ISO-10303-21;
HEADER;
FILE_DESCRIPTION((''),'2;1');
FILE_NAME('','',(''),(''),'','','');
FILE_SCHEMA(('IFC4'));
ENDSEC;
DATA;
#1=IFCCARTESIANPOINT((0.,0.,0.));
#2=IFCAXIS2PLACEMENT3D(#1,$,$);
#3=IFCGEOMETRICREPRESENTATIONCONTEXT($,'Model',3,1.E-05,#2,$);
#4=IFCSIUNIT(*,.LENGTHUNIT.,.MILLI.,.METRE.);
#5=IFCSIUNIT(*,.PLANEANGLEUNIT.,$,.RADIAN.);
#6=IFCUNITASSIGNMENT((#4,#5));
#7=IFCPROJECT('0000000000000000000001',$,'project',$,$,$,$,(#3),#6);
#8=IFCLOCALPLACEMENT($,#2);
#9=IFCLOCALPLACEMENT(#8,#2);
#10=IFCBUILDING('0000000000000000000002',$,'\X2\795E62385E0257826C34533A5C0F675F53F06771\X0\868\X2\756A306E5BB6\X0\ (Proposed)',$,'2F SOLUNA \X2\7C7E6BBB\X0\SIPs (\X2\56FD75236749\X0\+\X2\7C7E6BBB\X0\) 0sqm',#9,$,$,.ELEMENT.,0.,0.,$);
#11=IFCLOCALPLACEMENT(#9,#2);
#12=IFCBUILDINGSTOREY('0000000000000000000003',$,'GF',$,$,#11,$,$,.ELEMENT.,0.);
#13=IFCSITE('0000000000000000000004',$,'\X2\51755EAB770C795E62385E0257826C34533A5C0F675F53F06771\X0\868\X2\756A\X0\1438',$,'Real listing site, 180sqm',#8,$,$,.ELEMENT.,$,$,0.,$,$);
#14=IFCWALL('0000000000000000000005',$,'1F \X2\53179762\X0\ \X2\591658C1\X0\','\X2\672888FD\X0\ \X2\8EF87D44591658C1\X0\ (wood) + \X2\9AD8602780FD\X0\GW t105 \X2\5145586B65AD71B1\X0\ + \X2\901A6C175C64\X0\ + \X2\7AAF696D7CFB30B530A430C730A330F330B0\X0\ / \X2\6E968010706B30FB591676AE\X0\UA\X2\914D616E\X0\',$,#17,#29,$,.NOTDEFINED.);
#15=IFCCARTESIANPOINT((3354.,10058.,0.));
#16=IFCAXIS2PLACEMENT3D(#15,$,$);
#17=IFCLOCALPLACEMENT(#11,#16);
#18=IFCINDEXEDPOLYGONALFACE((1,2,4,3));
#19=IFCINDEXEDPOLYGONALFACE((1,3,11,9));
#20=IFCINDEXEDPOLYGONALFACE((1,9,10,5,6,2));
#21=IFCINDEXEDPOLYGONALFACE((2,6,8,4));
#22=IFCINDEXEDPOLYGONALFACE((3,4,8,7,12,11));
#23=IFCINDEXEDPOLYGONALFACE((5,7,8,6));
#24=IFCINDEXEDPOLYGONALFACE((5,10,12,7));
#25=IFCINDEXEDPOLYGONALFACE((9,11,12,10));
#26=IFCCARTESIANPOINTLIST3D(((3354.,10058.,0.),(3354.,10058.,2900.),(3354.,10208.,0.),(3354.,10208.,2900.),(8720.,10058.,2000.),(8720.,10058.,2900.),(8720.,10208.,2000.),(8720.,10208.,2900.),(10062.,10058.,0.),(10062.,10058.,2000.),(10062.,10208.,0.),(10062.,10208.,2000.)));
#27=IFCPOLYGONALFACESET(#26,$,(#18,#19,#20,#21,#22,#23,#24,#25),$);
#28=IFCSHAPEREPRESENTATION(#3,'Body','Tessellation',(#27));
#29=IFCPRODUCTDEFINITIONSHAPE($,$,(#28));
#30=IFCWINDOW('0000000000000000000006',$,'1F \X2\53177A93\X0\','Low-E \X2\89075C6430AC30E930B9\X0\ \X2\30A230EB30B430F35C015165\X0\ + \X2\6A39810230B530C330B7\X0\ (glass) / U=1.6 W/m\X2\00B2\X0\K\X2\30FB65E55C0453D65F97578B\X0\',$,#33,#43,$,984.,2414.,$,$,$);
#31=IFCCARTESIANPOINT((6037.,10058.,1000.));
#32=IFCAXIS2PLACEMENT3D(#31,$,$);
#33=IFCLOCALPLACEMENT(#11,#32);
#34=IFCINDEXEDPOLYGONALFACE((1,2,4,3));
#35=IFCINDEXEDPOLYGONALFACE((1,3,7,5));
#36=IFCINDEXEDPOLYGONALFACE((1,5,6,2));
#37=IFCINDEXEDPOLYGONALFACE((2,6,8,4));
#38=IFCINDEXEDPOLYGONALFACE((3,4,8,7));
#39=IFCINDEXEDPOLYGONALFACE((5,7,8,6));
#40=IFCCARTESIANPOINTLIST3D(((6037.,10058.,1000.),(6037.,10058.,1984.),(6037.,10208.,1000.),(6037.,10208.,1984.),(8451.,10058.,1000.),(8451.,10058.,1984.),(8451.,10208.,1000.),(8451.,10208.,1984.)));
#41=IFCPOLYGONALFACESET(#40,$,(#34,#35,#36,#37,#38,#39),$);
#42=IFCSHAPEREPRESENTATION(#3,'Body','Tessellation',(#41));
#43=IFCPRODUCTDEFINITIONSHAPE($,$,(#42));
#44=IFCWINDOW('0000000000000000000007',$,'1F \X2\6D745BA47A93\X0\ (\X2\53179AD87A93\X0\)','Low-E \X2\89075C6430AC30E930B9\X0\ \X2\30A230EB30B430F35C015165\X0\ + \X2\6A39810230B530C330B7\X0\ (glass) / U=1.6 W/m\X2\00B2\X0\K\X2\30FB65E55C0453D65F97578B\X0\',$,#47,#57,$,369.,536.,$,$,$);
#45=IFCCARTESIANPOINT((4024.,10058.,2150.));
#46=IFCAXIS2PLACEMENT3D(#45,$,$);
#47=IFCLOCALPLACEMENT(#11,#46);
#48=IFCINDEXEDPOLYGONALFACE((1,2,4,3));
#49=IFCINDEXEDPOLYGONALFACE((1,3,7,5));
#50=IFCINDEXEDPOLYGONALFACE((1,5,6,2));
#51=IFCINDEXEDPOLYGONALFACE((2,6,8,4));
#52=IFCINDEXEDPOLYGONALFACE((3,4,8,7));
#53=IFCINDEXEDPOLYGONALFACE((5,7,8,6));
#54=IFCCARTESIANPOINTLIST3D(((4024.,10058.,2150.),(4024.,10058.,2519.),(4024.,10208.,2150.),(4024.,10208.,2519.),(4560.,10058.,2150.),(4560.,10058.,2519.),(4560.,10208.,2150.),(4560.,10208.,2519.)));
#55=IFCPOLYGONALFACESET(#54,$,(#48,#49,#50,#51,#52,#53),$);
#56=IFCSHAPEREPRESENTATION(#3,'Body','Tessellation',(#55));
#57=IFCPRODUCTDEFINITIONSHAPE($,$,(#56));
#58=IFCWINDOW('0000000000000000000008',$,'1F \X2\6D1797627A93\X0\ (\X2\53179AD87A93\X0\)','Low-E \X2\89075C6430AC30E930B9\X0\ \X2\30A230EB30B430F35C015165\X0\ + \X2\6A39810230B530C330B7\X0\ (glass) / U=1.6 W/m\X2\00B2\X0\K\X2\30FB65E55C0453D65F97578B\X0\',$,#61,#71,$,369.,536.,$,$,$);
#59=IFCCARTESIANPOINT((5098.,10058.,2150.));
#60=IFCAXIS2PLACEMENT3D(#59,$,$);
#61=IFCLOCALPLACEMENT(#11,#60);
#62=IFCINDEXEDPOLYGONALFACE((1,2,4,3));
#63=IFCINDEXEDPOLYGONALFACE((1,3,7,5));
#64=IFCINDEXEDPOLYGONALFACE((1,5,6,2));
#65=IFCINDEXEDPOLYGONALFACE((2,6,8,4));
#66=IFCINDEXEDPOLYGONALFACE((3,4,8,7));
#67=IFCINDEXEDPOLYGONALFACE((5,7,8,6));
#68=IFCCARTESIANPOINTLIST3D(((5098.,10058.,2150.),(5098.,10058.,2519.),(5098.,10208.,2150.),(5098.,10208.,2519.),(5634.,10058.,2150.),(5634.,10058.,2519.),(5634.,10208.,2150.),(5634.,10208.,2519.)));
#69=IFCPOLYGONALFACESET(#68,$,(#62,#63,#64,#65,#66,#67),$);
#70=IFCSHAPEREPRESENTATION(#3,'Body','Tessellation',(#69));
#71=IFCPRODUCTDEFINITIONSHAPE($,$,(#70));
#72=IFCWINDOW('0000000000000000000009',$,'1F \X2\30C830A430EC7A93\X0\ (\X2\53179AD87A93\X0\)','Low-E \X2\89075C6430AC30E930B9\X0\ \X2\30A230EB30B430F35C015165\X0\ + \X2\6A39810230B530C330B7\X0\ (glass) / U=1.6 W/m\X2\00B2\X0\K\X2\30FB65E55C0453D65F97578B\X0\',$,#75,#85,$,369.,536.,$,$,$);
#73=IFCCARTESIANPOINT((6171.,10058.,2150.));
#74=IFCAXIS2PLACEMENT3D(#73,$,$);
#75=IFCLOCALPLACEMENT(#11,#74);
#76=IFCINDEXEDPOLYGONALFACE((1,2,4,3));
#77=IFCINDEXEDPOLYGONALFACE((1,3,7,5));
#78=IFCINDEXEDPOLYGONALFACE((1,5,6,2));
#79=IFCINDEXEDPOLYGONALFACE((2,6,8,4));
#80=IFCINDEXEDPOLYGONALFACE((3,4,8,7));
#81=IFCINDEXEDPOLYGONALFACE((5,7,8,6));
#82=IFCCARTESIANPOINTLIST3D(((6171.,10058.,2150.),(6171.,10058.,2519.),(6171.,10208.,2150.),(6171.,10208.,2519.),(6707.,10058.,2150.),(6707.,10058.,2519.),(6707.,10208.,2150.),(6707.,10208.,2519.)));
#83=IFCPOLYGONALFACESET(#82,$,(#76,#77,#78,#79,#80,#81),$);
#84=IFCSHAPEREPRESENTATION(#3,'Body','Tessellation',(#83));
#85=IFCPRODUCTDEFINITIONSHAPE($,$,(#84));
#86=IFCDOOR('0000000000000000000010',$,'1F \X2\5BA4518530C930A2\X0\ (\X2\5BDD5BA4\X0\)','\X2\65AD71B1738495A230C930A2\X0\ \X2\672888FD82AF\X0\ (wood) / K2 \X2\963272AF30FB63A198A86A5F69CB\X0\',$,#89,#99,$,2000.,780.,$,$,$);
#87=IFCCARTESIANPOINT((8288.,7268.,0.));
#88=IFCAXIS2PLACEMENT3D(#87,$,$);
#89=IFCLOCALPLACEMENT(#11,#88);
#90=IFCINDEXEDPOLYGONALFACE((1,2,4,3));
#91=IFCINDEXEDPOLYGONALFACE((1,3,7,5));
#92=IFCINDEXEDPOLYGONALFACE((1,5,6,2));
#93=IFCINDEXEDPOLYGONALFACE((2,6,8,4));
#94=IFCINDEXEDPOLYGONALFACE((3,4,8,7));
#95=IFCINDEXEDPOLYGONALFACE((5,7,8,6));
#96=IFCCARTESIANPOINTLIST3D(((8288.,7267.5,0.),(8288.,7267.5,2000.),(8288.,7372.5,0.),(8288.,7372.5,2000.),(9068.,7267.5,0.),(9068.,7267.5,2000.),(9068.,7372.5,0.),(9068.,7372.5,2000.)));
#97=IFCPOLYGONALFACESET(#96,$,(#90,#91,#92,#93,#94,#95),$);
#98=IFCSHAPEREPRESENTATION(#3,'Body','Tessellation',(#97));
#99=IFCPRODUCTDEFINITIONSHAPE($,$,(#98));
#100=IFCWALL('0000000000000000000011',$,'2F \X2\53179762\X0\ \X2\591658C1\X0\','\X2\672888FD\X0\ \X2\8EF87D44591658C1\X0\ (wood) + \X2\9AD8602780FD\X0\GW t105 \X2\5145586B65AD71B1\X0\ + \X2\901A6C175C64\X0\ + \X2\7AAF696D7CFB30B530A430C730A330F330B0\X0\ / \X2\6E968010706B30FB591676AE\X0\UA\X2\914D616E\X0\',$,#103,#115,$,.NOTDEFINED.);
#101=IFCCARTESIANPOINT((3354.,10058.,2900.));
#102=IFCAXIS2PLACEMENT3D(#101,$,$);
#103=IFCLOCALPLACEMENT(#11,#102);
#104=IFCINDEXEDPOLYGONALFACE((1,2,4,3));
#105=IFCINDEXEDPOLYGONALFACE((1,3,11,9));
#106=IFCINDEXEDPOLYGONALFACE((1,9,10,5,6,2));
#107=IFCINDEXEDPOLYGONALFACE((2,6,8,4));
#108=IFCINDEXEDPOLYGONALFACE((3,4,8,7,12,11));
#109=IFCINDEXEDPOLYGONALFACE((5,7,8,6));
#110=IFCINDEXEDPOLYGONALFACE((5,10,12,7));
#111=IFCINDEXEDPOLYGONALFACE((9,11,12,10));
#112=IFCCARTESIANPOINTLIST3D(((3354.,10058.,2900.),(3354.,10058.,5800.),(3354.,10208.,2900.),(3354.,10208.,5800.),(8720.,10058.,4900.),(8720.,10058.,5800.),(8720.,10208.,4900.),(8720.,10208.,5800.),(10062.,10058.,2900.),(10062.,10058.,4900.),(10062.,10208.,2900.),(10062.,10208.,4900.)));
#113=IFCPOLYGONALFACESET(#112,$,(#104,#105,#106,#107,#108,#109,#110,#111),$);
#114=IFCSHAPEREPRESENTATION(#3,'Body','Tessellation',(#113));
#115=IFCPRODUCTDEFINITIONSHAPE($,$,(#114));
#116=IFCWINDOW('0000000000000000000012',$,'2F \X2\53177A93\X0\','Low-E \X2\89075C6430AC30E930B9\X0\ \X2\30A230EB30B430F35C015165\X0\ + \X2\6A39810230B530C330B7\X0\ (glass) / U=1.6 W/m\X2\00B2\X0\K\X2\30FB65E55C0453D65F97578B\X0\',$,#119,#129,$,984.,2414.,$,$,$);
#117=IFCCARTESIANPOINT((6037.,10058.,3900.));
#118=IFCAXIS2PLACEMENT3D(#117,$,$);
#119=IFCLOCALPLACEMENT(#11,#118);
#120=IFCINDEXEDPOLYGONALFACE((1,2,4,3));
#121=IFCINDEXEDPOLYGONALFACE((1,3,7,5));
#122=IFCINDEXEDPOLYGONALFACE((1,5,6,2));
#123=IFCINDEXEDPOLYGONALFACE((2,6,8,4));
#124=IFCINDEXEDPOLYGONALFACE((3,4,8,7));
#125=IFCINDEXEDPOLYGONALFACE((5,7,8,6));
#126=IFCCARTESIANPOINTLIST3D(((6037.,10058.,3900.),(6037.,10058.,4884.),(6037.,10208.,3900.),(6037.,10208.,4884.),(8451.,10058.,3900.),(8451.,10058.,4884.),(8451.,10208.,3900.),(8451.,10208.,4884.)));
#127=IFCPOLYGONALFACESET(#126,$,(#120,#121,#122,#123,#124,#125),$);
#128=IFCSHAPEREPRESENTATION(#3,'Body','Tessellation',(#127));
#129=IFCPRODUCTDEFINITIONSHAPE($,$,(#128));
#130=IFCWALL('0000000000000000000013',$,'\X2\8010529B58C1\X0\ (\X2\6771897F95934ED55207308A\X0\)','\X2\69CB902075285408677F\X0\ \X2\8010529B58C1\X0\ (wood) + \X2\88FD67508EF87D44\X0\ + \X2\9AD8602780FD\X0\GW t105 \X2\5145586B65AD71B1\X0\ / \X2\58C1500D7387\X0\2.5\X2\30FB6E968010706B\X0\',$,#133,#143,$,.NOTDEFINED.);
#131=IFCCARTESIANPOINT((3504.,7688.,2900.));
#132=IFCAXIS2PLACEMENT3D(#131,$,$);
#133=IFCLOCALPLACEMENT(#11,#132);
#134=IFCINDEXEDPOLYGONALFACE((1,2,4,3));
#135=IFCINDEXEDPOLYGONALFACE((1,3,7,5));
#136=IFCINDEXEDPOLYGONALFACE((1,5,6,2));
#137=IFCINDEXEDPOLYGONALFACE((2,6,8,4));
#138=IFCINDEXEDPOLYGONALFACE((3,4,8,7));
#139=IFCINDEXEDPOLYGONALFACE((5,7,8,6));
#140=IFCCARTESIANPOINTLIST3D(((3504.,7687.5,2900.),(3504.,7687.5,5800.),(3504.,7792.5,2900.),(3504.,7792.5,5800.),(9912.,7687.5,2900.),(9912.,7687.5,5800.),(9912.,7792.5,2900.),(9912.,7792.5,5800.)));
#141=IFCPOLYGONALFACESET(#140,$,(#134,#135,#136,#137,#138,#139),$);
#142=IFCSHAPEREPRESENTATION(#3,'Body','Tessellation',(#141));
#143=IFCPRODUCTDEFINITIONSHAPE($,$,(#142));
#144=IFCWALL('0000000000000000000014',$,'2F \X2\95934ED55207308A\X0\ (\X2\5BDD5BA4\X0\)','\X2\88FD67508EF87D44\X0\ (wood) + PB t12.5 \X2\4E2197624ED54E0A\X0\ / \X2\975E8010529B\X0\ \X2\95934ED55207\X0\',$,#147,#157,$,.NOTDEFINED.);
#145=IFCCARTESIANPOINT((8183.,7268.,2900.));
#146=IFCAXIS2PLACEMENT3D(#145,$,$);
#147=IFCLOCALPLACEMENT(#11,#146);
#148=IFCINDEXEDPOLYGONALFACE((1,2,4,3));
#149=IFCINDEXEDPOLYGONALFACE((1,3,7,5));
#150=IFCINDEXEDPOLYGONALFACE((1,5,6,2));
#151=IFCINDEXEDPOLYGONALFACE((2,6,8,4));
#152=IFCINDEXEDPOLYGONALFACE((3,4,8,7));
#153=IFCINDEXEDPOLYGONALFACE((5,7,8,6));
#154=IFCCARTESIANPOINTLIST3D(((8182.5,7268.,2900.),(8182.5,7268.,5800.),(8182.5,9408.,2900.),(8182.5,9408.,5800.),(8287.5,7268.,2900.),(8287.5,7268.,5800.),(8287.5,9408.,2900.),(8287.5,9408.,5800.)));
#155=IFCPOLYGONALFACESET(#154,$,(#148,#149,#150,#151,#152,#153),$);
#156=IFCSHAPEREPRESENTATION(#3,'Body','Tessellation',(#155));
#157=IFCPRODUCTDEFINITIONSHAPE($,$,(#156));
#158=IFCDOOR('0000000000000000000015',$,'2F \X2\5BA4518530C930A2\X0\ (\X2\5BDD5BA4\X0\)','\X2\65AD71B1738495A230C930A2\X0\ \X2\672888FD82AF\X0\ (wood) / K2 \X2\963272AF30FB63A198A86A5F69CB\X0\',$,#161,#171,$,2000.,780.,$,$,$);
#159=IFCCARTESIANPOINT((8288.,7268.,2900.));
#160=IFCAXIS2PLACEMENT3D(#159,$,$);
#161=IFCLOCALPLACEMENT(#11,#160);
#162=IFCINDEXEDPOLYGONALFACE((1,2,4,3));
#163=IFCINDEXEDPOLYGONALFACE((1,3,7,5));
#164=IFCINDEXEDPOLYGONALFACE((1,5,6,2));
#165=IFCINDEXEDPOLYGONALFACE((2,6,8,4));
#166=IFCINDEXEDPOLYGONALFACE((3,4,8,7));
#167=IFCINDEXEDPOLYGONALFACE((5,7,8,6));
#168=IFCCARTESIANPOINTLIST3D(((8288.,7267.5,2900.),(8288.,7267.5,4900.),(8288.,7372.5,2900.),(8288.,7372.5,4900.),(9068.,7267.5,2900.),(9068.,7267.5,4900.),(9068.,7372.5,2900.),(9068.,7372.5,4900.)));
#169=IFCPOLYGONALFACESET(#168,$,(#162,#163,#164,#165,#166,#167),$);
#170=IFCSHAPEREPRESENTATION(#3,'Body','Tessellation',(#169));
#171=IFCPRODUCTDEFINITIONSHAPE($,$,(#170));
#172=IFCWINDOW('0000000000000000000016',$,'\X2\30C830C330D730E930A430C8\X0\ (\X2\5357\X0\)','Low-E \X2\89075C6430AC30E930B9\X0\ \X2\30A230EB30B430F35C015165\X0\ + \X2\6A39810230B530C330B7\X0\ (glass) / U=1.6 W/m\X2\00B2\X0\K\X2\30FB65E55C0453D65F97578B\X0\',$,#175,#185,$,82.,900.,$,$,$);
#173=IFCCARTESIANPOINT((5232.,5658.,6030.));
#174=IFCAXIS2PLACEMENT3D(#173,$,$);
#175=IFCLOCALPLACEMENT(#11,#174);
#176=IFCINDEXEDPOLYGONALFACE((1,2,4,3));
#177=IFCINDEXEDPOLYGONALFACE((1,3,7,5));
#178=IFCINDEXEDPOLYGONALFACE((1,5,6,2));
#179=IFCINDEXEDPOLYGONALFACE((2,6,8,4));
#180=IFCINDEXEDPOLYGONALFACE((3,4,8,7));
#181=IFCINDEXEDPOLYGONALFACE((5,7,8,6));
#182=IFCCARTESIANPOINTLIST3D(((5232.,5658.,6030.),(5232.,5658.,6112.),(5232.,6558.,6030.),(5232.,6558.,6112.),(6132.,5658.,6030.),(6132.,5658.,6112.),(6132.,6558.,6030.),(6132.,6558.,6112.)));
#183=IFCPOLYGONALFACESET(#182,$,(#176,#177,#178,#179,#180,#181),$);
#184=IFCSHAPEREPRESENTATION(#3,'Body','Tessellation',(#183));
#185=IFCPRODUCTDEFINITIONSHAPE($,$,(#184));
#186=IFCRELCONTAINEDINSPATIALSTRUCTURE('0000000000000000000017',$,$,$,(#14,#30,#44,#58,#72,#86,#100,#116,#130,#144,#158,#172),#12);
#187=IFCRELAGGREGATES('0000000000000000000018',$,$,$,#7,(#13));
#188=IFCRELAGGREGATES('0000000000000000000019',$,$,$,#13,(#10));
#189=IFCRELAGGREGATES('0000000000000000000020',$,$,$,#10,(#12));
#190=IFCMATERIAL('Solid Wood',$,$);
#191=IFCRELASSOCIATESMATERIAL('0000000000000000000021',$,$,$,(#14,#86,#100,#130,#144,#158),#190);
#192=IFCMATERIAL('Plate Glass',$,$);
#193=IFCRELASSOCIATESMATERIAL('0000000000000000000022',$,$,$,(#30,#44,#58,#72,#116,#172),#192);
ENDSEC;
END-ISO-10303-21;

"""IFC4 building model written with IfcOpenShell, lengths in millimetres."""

from ifc_helpers import new_model, si_unit, frame, frame_2d, origin, place, context, project, spatial, rectangle, extrude, material, element, fill, save


model = new_model("IFC4")

# Units and contexts
model_context = context("Model", 3, precision=1e-05, world=origin())
ifc_project = project(units=[si_unit("LENGTHUNIT", "METRE", prefix="MILLI"), si_unit("PLANEANGLEUNIT", "RADIAN")], contexts=[model_context])

# Site, building, storey
site_placement = place(None, origin())
site = spatial("IfcSite", under=ifc_project, at=site_placement, Name="兵庫県神戸市垂水区小束台東868番1438", ObjectType="Real listing site, 180sqm", CompositionType="ELEMENT", RefElevation=0.0)
building_placement = place(site_placement, origin())
building = spatial("IfcBuilding", under=site, at=building_placement, Name="神戸市垂水区小束台東868番の家 (Proposed)", ObjectType="2F SOLUNA 籾殻SIPs (国産杉+籾殻) 0sqm", CompositionType="ELEMENT", ElevationOfRefHeight=0.0, ElevationOfTerrain=0.0)
storey_placement = place(building_placement, origin())
storey = spatial("IfcBuildingStorey", under=building, at=storey_placement, Name="GF", CompositionType="ELEMENT", Elevation=0.0)

# Wall, openings, windows
ifc_material_1 = material(Name="Solid Wood")
wall_1_placement = place(storey_placement, frame((3354.0, 10058.0, 0.0)))
wall_1 = element("IfcWall", 1, at=wall_1_placement, inside=storey, material=ifc_material_1, Name="1F 北面 外壁", Description="木製 軸組外壁 (wood) + 高性能GW t105 充填断熱 + 通気層 + 窯業系サイディング / 準耐火・外皮UA配慮", PredefinedType="NOTDEFINED", context=model_context, shape_type="SweptSolid", body=[
    extrude(rectangle(XDim=6708.0, YDim=150.0, at=frame_2d((3354.0, 75.0))), frame((3354.0, 10058.0, 0.0)), (0.0, 0.0, 1.0), 2900.0),
])
opening_1_placement = place(storey_placement, frame((6037.0, 10058.0, 1000.0)))
opening_1 = element("IfcOpeningElement", 2, at=opening_1_placement, cuts=wall_1, PredefinedType="NOTDEFINED", context=model_context, shape_type="SweptSolid", body=[
    extrude(rectangle(XDim=2414.0, YDim=150.0, at=frame_2d((1207.0, 75.0))), frame((6037.0, 10058.0, 1000.0)), (0.0, 0.0, 1.0), 984.0),
])
opening_2_placement = place(storey_placement, frame((4024.0, 10058.0, 2150.0)))
opening_2 = element("IfcOpeningElement", 3, at=opening_2_placement, cuts=wall_1, PredefinedType="NOTDEFINED", context=model_context, shape_type="SweptSolid", body=[
    extrude(rectangle(XDim=536.0, YDim=150.0, at=frame_2d((268.0, 75.0))), frame((4024.0, 10058.0, 2150.0)), (0.0, 0.0, 1.0), 369.0),
])
opening_3_placement = place(storey_placement, frame((5098.0, 10058.0, 2150.0)))
opening_3 = element("IfcOpeningElement", 4, at=opening_3_placement, cuts=wall_1, PredefinedType="NOTDEFINED", context=model_context, shape_type="SweptSolid", body=[
    extrude(rectangle(XDim=536.0, YDim=150.0, at=frame_2d((268.0, 75.0))), frame((5098.0, 10058.0, 2150.0)), (0.0, 0.0, 1.0), 369.0),
])
opening_4_placement = place(storey_placement, frame((6171.0, 10058.0, 2150.0)))
opening_4 = element("IfcOpeningElement", 5, at=opening_4_placement, cuts=wall_1, PredefinedType="NOTDEFINED", context=model_context, shape_type="SweptSolid", body=[
    extrude(rectangle(XDim=536.0, YDim=150.0, at=frame_2d((268.0, 75.0))), frame((6171.0, 10058.0, 2150.0)), (0.0, 0.0, 1.0), 369.0),
])
ifc_material_2 = material(Name="Plate Glass")
window_1_placement = place(storey_placement, frame((6037.0, 10058.0, 1000.0)))
window_1 = element("IfcWindow", 6, at=window_1_placement, inside=storey, material=ifc_material_2, Name="1F 北窓", Description="Low-E 複層ガラス アルゴン封入 + 樹脂サッシ (glass) / U=1.6 W/m²K・日射取得型", OverallHeight=984.0, OverallWidth=2414.0, context=model_context, shape_type="SweptSolid", body=[
    extrude(rectangle(XDim=2414.0, YDim=150.0, at=frame_2d((1207.0, 75.0))), frame((6037.0, 10058.0, 1000.0)), (0.0, 0.0, 1.0), 984.0),
])
fill(opening_1, window_1)
window_2_placement = place(storey_placement, frame((4024.0, 10058.0, 2150.0)))
window_2 = element("IfcWindow", 7, at=window_2_placement, inside=storey, material=ifc_material_2, Name="1F 浴室窓 (北高窓)", Description="Low-E 複層ガラス アルゴン封入 + 樹脂サッシ (glass) / U=1.6 W/m²K・日射取得型", OverallHeight=369.0, OverallWidth=536.0, context=model_context, shape_type="SweptSolid", body=[
    extrude(rectangle(XDim=536.0, YDim=150.0, at=frame_2d((268.0, 75.0))), frame((4024.0, 10058.0, 2150.0)), (0.0, 0.0, 1.0), 369.0),
])
fill(opening_2, window_2)
window_3_placement = place(storey_placement, frame((5098.0, 10058.0, 2150.0)))
window_3 = element("IfcWindow", 8, at=window_3_placement, inside=storey, material=ifc_material_2, Name="1F 洗面窓 (北高窓)", Description="Low-E 複層ガラス アルゴン封入 + 樹脂サッシ (glass) / U=1.6 W/m²K・日射取得型", OverallHeight=369.0, OverallWidth=536.0, context=model_context, shape_type="SweptSolid", body=[
    extrude(rectangle(XDim=536.0, YDim=150.0, at=frame_2d((268.0, 75.0))), frame((5098.0, 10058.0, 2150.0)), (0.0, 0.0, 1.0), 369.0),
])
fill(opening_3, window_3)
window_4_placement = place(storey_placement, frame((6171.0, 10058.0, 2150.0)))
window_4 = element("IfcWindow", 9, at=window_4_placement, inside=storey, material=ifc_material_2, Name="1F トイレ窓 (北高窓)", Description="Low-E 複層ガラス アルゴン封入 + 樹脂サッシ (glass) / U=1.6 W/m²K・日射取得型", OverallHeight=369.0, OverallWidth=536.0, context=model_context, shape_type="SweptSolid", body=[
    extrude(rectangle(XDim=536.0, YDim=150.0, at=frame_2d((268.0, 75.0))), frame((6171.0, 10058.0, 2150.0)), (0.0, 0.0, 1.0), 369.0),
])
fill(opening_4, window_4)

# Door
door_1_placement = place(storey_placement, frame((8288.0, 7268.0, 0.0)))
element("IfcDoor", 10, at=door_1_placement, inside=storey, material=ifc_material_1, Name="1F 室内ドア (寝室)", Description="断熱玄関ドア 木製芯 (wood) / K2 防犯・採風機構", OverallHeight=2000.0, OverallWidth=780.0, context=model_context, shape_type="SweptSolid", body=[
    extrude(rectangle(XDim=780.0, YDim=105.0, at=frame_2d((390.0, 52.0))), frame((8288.0, 7268.0, 0.0)), (0.0, 0.0, 1.0), 2000.0),
])

# Wall, opening, window
wall_2_placement = place(storey_placement, frame((3354.0, 10058.0, 2900.0)))
wall_2 = element("IfcWall", 11, at=wall_2_placement, inside=storey, material=ifc_material_1, Name="2F 北面 外壁", Description="木製 軸組外壁 (wood) + 高性能GW t105 充填断熱 + 通気層 + 窯業系サイディング / 準耐火・外皮UA配慮", PredefinedType="NOTDEFINED", context=model_context, shape_type="SweptSolid", body=[
    extrude(rectangle(XDim=6708.0, YDim=150.0, at=frame_2d((3354.0, 75.0))), frame((3354.0, 10058.0, 2900.0)), (0.0, 0.0, 1.0), 2900.0),
])
opening_5_placement = place(storey_placement, frame((6037.0, 10058.0, 3900.0)))
opening_5 = element("IfcOpeningElement", 12, at=opening_5_placement, cuts=wall_2, PredefinedType="NOTDEFINED", context=model_context, shape_type="SweptSolid", body=[
    extrude(rectangle(XDim=2414.0, YDim=150.0, at=frame_2d((1207.0, 75.0))), frame((6037.0, 10058.0, 3900.0)), (0.0, 0.0, 1.0), 984.0),
])
window_5_placement = place(storey_placement, frame((6037.0, 10058.0, 3900.0)))
window_5 = element("IfcWindow", 13, at=window_5_placement, inside=storey, material=ifc_material_2, Name="2F 北窓", Description="Low-E 複層ガラス アルゴン封入 + 樹脂サッシ (glass) / U=1.6 W/m²K・日射取得型", OverallHeight=984.0, OverallWidth=2414.0, context=model_context, shape_type="SweptSolid", body=[
    extrude(rectangle(XDim=2414.0, YDim=150.0, at=frame_2d((1207.0, 75.0))), frame((6037.0, 10058.0, 3900.0)), (0.0, 0.0, 1.0), 984.0),
])
fill(opening_5, window_5)

# Walls
wall_3_placement = place(storey_placement, frame((3504.0, 7688.0, 2900.0)))
element("IfcWall", 14, at=wall_3_placement, inside=storey, material=ifc_material_1, Name="耐力壁 (東西間仕切り)", Description="構造用合板 耐力壁 (wood) + 製材軸組 + 高性能GW t105 充填断熱 / 壁倍率2.5・準耐火", PredefinedType="NOTDEFINED", context=model_context, shape_type="SweptSolid", body=[
    extrude(rectangle(XDim=6408.0, YDim=105.0, at=frame_2d((3204.0, 52.0))), frame((3504.0, 7688.0, 2900.0)), (0.0, 0.0, 1.0), 2900.0),
])
wall_4_placement = place(storey_placement, frame((8183.0, 7268.0, 2900.0)))
element("IfcWall", 15, at=wall_4_placement, inside=storey, material=ifc_material_1, Name="2F 間仕切り (寝室)", Description="製材軸組 (wood) + PB t12.5 両面仕上 / 非耐力 間仕切", PredefinedType="NOTDEFINED", context=model_context, shape_type="SweptSolid", body=[
    extrude(rectangle(XDim=105.0, YDim=2140.0, at=frame_2d((52.0, 1070.0))), frame((8183.0, 7268.0, 2900.0)), (0.0, 0.0, 1.0), 2900.0),
])

# Door
door_2_placement = place(storey_placement, frame((8288.0, 7268.0, 2900.0)))
element("IfcDoor", 16, at=door_2_placement, inside=storey, material=ifc_material_1, Name="2F 室内ドア (寝室)", Description="断熱玄関ドア 木製芯 (wood) / K2 防犯・採風機構", OverallHeight=2000.0, OverallWidth=780.0, context=model_context, shape_type="SweptSolid", body=[
    extrude(rectangle(XDim=780.0, YDim=105.0, at=frame_2d((390.0, 52.0))), frame((8288.0, 7268.0, 2900.0)), (0.0, 0.0, 1.0), 2000.0),
])

# Window
window_6_placement = place(storey_placement, frame((5232.0, 5658.0, 6030.0)))
element("IfcWindow", 17, at=window_6_placement, inside=storey, material=ifc_material_2, Name="トップライト (南)", Description="Low-E 複層ガラス アルゴン封入 + 樹脂サッシ (glass) / U=1.6 W/m²K・日射取得型", OverallHeight=82.0, OverallWidth=900.0, context=model_context, shape_type="SweptSolid", body=[
    extrude(rectangle(XDim=900.0, YDim=900.0, at=frame_2d((450.0, 450.0))), frame((5232.0, 5658.0, 6030.0)), (0.0, 0.0, 1.0), 82.0),
])

save(model, "model.ifc")
